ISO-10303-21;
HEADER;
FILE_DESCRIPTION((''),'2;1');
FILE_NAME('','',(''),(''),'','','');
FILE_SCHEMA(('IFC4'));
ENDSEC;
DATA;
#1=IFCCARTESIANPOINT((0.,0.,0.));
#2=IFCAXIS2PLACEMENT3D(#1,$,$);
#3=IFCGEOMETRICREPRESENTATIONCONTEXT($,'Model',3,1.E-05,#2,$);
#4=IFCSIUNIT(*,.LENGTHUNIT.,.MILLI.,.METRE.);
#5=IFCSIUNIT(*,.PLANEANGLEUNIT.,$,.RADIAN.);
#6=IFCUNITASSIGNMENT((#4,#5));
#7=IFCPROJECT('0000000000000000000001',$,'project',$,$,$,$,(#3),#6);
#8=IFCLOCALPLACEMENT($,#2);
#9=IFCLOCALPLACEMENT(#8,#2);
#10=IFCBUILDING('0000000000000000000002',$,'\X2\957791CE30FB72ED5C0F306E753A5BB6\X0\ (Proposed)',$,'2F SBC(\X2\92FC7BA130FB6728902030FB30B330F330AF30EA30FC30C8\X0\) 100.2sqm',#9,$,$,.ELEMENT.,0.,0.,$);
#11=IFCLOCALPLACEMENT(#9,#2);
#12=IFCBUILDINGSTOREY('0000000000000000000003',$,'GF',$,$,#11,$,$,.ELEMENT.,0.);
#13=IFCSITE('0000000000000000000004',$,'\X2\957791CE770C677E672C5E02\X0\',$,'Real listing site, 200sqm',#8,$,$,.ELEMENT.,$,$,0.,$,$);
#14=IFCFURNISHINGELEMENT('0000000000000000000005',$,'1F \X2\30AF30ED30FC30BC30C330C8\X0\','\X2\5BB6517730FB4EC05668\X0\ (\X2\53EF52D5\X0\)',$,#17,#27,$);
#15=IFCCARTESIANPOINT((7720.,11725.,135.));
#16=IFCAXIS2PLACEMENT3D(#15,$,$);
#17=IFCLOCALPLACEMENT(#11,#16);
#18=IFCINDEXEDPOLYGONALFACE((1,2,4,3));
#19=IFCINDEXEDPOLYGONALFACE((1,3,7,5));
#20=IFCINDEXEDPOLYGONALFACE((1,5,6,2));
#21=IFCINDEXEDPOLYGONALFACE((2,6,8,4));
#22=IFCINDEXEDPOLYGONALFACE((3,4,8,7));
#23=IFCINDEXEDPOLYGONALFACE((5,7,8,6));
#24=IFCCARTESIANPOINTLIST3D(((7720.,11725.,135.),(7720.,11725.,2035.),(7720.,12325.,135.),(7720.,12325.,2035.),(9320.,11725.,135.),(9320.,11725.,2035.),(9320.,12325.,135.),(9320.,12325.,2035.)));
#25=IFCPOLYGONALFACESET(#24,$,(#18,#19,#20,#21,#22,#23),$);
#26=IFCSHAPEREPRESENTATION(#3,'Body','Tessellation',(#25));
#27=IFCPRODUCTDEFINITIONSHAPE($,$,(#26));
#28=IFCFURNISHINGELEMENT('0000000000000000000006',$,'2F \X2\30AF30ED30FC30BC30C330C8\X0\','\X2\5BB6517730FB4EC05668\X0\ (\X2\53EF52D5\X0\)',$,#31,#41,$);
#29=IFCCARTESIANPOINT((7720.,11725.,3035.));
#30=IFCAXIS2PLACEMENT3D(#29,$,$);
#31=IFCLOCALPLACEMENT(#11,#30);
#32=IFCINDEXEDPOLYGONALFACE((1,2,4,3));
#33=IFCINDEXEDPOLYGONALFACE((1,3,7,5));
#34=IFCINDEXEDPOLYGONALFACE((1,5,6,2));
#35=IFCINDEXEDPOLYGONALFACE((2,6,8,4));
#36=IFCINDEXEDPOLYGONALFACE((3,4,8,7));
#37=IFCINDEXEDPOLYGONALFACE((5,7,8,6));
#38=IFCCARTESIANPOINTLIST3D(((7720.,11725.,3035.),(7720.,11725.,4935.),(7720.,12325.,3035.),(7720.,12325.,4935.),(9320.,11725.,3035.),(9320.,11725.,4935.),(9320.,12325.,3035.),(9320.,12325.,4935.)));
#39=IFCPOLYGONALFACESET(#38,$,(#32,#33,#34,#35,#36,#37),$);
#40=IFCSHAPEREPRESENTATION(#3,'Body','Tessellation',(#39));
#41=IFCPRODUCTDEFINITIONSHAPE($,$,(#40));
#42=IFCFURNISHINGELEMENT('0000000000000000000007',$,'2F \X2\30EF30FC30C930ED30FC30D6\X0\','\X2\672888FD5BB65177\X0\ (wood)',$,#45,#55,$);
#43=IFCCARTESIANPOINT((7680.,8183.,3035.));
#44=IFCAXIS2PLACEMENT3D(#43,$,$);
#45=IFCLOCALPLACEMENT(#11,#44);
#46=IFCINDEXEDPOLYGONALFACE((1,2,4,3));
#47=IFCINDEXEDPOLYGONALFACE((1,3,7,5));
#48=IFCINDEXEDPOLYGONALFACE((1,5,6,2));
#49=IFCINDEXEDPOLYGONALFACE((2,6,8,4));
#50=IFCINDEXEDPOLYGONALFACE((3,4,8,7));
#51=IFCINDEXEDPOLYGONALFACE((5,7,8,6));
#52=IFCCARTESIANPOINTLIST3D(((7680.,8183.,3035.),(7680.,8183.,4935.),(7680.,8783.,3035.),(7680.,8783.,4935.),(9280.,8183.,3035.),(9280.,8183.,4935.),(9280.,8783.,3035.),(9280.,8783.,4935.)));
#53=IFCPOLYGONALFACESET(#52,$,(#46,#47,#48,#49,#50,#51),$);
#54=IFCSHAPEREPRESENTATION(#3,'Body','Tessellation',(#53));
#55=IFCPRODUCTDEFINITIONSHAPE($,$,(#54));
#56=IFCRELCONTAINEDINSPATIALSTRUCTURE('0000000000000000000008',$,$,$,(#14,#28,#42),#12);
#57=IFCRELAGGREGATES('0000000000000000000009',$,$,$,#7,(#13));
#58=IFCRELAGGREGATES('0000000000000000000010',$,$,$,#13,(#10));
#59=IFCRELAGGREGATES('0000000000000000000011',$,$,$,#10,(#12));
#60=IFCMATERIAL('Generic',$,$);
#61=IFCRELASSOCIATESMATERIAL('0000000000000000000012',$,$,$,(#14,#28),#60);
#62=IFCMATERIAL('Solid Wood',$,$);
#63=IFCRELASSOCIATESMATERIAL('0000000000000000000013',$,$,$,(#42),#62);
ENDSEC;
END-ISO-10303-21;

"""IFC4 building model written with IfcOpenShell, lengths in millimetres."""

from ifc_helpers import new_model, si_unit, frame, frame_2d, origin, place, context, project, spatial, rectangle, extrude, material, element, save


model = new_model("IFC4")

# Units and contexts
model_context = context("Model", 3, precision=1e-05, world=origin())
ifc_project = project(units=[si_unit("LENGTHUNIT", "METRE", prefix="MILLI"), si_unit("PLANEANGLEUNIT", "RADIAN")], contexts=[model_context])

# Site, building, storey
site_placement = place(None, origin())
site = spatial("IfcSite", under=ifc_project, at=site_placement, Name="長野県松本市", ObjectType="Real listing site, 200sqm", CompositionType="ELEMENT", RefElevation=0.0)
building_placement = place(site_placement, origin())
building = spatial("IfcBuilding", under=site, at=building_placement, Name="長野・狭小の町家 (Proposed)", ObjectType="2F SBC(鋼管・木造・コンクリート) 100.2sqm", CompositionType="ELEMENT", ElevationOfRefHeight=0.0, ElevationOfTerrain=0.0)
storey_placement = place(building_placement, origin())
storey = spatial("IfcBuildingStorey", under=building, at=storey_placement, Name="GF", CompositionType="ELEMENT", Elevation=0.0)

# Shared definitions
ifc_material_1 = material(Name="Solid Wood")

# Shared definitions
ifc_material_2 = material(Name="Generic")

# Furnishing elements
furnishing_1_placement = place(storey_placement, frame((7720.0, 11725.0, 135.0)))
element("IfcFurnishingElement", 1, at=furnishing_1_placement, inside=storey, material=ifc_material_2, Name="1F クローゼット", Description="家具・什器 (可動)", context=model_context, shape_type="SweptSolid", body=[
    extrude(rectangle(XDim=1600.0, YDim=600.0, at=frame_2d((800.0, 300.0))), frame((7720.0, 11725.0, 135.0)), (0.0, 0.0, 1.0), 1900.0),
])
furnishing_2_placement = place(storey_placement, frame((7720.0, 11725.0, 3035.0)))
element("IfcFurnishingElement", 2, at=furnishing_2_placement, inside=storey, material=ifc_material_2, Name="2F クローゼット", Description="家具・什器 (可動)", context=model_context, shape_type="SweptSolid", body=[
    extrude(rectangle(XDim=1600.0, YDim=600.0, at=frame_2d((800.0, 300.0))), frame((7720.0, 11725.0, 3035.0)), (0.0, 0.0, 1.0), 1900.0),
])
furnishing_3_placement = place(storey_placement, frame((7680.0, 8183.0, 3035.0)))
element("IfcFurnishingElement", 3, at=furnishing_3_placement, inside=storey, material=ifc_material_1, Name="2F ワードローブ", Description="木製家具 (wood)", context=model_context, shape_type="SweptSolid", body=[
    extrude(rectangle(XDim=1600.0, YDim=600.0, at=frame_2d((800.0, 300.0))), frame((7680.0, 8183.0, 3035.0)), (0.0, 0.0, 1.0), 1900.0),
])

save(model, "model.ifc")
